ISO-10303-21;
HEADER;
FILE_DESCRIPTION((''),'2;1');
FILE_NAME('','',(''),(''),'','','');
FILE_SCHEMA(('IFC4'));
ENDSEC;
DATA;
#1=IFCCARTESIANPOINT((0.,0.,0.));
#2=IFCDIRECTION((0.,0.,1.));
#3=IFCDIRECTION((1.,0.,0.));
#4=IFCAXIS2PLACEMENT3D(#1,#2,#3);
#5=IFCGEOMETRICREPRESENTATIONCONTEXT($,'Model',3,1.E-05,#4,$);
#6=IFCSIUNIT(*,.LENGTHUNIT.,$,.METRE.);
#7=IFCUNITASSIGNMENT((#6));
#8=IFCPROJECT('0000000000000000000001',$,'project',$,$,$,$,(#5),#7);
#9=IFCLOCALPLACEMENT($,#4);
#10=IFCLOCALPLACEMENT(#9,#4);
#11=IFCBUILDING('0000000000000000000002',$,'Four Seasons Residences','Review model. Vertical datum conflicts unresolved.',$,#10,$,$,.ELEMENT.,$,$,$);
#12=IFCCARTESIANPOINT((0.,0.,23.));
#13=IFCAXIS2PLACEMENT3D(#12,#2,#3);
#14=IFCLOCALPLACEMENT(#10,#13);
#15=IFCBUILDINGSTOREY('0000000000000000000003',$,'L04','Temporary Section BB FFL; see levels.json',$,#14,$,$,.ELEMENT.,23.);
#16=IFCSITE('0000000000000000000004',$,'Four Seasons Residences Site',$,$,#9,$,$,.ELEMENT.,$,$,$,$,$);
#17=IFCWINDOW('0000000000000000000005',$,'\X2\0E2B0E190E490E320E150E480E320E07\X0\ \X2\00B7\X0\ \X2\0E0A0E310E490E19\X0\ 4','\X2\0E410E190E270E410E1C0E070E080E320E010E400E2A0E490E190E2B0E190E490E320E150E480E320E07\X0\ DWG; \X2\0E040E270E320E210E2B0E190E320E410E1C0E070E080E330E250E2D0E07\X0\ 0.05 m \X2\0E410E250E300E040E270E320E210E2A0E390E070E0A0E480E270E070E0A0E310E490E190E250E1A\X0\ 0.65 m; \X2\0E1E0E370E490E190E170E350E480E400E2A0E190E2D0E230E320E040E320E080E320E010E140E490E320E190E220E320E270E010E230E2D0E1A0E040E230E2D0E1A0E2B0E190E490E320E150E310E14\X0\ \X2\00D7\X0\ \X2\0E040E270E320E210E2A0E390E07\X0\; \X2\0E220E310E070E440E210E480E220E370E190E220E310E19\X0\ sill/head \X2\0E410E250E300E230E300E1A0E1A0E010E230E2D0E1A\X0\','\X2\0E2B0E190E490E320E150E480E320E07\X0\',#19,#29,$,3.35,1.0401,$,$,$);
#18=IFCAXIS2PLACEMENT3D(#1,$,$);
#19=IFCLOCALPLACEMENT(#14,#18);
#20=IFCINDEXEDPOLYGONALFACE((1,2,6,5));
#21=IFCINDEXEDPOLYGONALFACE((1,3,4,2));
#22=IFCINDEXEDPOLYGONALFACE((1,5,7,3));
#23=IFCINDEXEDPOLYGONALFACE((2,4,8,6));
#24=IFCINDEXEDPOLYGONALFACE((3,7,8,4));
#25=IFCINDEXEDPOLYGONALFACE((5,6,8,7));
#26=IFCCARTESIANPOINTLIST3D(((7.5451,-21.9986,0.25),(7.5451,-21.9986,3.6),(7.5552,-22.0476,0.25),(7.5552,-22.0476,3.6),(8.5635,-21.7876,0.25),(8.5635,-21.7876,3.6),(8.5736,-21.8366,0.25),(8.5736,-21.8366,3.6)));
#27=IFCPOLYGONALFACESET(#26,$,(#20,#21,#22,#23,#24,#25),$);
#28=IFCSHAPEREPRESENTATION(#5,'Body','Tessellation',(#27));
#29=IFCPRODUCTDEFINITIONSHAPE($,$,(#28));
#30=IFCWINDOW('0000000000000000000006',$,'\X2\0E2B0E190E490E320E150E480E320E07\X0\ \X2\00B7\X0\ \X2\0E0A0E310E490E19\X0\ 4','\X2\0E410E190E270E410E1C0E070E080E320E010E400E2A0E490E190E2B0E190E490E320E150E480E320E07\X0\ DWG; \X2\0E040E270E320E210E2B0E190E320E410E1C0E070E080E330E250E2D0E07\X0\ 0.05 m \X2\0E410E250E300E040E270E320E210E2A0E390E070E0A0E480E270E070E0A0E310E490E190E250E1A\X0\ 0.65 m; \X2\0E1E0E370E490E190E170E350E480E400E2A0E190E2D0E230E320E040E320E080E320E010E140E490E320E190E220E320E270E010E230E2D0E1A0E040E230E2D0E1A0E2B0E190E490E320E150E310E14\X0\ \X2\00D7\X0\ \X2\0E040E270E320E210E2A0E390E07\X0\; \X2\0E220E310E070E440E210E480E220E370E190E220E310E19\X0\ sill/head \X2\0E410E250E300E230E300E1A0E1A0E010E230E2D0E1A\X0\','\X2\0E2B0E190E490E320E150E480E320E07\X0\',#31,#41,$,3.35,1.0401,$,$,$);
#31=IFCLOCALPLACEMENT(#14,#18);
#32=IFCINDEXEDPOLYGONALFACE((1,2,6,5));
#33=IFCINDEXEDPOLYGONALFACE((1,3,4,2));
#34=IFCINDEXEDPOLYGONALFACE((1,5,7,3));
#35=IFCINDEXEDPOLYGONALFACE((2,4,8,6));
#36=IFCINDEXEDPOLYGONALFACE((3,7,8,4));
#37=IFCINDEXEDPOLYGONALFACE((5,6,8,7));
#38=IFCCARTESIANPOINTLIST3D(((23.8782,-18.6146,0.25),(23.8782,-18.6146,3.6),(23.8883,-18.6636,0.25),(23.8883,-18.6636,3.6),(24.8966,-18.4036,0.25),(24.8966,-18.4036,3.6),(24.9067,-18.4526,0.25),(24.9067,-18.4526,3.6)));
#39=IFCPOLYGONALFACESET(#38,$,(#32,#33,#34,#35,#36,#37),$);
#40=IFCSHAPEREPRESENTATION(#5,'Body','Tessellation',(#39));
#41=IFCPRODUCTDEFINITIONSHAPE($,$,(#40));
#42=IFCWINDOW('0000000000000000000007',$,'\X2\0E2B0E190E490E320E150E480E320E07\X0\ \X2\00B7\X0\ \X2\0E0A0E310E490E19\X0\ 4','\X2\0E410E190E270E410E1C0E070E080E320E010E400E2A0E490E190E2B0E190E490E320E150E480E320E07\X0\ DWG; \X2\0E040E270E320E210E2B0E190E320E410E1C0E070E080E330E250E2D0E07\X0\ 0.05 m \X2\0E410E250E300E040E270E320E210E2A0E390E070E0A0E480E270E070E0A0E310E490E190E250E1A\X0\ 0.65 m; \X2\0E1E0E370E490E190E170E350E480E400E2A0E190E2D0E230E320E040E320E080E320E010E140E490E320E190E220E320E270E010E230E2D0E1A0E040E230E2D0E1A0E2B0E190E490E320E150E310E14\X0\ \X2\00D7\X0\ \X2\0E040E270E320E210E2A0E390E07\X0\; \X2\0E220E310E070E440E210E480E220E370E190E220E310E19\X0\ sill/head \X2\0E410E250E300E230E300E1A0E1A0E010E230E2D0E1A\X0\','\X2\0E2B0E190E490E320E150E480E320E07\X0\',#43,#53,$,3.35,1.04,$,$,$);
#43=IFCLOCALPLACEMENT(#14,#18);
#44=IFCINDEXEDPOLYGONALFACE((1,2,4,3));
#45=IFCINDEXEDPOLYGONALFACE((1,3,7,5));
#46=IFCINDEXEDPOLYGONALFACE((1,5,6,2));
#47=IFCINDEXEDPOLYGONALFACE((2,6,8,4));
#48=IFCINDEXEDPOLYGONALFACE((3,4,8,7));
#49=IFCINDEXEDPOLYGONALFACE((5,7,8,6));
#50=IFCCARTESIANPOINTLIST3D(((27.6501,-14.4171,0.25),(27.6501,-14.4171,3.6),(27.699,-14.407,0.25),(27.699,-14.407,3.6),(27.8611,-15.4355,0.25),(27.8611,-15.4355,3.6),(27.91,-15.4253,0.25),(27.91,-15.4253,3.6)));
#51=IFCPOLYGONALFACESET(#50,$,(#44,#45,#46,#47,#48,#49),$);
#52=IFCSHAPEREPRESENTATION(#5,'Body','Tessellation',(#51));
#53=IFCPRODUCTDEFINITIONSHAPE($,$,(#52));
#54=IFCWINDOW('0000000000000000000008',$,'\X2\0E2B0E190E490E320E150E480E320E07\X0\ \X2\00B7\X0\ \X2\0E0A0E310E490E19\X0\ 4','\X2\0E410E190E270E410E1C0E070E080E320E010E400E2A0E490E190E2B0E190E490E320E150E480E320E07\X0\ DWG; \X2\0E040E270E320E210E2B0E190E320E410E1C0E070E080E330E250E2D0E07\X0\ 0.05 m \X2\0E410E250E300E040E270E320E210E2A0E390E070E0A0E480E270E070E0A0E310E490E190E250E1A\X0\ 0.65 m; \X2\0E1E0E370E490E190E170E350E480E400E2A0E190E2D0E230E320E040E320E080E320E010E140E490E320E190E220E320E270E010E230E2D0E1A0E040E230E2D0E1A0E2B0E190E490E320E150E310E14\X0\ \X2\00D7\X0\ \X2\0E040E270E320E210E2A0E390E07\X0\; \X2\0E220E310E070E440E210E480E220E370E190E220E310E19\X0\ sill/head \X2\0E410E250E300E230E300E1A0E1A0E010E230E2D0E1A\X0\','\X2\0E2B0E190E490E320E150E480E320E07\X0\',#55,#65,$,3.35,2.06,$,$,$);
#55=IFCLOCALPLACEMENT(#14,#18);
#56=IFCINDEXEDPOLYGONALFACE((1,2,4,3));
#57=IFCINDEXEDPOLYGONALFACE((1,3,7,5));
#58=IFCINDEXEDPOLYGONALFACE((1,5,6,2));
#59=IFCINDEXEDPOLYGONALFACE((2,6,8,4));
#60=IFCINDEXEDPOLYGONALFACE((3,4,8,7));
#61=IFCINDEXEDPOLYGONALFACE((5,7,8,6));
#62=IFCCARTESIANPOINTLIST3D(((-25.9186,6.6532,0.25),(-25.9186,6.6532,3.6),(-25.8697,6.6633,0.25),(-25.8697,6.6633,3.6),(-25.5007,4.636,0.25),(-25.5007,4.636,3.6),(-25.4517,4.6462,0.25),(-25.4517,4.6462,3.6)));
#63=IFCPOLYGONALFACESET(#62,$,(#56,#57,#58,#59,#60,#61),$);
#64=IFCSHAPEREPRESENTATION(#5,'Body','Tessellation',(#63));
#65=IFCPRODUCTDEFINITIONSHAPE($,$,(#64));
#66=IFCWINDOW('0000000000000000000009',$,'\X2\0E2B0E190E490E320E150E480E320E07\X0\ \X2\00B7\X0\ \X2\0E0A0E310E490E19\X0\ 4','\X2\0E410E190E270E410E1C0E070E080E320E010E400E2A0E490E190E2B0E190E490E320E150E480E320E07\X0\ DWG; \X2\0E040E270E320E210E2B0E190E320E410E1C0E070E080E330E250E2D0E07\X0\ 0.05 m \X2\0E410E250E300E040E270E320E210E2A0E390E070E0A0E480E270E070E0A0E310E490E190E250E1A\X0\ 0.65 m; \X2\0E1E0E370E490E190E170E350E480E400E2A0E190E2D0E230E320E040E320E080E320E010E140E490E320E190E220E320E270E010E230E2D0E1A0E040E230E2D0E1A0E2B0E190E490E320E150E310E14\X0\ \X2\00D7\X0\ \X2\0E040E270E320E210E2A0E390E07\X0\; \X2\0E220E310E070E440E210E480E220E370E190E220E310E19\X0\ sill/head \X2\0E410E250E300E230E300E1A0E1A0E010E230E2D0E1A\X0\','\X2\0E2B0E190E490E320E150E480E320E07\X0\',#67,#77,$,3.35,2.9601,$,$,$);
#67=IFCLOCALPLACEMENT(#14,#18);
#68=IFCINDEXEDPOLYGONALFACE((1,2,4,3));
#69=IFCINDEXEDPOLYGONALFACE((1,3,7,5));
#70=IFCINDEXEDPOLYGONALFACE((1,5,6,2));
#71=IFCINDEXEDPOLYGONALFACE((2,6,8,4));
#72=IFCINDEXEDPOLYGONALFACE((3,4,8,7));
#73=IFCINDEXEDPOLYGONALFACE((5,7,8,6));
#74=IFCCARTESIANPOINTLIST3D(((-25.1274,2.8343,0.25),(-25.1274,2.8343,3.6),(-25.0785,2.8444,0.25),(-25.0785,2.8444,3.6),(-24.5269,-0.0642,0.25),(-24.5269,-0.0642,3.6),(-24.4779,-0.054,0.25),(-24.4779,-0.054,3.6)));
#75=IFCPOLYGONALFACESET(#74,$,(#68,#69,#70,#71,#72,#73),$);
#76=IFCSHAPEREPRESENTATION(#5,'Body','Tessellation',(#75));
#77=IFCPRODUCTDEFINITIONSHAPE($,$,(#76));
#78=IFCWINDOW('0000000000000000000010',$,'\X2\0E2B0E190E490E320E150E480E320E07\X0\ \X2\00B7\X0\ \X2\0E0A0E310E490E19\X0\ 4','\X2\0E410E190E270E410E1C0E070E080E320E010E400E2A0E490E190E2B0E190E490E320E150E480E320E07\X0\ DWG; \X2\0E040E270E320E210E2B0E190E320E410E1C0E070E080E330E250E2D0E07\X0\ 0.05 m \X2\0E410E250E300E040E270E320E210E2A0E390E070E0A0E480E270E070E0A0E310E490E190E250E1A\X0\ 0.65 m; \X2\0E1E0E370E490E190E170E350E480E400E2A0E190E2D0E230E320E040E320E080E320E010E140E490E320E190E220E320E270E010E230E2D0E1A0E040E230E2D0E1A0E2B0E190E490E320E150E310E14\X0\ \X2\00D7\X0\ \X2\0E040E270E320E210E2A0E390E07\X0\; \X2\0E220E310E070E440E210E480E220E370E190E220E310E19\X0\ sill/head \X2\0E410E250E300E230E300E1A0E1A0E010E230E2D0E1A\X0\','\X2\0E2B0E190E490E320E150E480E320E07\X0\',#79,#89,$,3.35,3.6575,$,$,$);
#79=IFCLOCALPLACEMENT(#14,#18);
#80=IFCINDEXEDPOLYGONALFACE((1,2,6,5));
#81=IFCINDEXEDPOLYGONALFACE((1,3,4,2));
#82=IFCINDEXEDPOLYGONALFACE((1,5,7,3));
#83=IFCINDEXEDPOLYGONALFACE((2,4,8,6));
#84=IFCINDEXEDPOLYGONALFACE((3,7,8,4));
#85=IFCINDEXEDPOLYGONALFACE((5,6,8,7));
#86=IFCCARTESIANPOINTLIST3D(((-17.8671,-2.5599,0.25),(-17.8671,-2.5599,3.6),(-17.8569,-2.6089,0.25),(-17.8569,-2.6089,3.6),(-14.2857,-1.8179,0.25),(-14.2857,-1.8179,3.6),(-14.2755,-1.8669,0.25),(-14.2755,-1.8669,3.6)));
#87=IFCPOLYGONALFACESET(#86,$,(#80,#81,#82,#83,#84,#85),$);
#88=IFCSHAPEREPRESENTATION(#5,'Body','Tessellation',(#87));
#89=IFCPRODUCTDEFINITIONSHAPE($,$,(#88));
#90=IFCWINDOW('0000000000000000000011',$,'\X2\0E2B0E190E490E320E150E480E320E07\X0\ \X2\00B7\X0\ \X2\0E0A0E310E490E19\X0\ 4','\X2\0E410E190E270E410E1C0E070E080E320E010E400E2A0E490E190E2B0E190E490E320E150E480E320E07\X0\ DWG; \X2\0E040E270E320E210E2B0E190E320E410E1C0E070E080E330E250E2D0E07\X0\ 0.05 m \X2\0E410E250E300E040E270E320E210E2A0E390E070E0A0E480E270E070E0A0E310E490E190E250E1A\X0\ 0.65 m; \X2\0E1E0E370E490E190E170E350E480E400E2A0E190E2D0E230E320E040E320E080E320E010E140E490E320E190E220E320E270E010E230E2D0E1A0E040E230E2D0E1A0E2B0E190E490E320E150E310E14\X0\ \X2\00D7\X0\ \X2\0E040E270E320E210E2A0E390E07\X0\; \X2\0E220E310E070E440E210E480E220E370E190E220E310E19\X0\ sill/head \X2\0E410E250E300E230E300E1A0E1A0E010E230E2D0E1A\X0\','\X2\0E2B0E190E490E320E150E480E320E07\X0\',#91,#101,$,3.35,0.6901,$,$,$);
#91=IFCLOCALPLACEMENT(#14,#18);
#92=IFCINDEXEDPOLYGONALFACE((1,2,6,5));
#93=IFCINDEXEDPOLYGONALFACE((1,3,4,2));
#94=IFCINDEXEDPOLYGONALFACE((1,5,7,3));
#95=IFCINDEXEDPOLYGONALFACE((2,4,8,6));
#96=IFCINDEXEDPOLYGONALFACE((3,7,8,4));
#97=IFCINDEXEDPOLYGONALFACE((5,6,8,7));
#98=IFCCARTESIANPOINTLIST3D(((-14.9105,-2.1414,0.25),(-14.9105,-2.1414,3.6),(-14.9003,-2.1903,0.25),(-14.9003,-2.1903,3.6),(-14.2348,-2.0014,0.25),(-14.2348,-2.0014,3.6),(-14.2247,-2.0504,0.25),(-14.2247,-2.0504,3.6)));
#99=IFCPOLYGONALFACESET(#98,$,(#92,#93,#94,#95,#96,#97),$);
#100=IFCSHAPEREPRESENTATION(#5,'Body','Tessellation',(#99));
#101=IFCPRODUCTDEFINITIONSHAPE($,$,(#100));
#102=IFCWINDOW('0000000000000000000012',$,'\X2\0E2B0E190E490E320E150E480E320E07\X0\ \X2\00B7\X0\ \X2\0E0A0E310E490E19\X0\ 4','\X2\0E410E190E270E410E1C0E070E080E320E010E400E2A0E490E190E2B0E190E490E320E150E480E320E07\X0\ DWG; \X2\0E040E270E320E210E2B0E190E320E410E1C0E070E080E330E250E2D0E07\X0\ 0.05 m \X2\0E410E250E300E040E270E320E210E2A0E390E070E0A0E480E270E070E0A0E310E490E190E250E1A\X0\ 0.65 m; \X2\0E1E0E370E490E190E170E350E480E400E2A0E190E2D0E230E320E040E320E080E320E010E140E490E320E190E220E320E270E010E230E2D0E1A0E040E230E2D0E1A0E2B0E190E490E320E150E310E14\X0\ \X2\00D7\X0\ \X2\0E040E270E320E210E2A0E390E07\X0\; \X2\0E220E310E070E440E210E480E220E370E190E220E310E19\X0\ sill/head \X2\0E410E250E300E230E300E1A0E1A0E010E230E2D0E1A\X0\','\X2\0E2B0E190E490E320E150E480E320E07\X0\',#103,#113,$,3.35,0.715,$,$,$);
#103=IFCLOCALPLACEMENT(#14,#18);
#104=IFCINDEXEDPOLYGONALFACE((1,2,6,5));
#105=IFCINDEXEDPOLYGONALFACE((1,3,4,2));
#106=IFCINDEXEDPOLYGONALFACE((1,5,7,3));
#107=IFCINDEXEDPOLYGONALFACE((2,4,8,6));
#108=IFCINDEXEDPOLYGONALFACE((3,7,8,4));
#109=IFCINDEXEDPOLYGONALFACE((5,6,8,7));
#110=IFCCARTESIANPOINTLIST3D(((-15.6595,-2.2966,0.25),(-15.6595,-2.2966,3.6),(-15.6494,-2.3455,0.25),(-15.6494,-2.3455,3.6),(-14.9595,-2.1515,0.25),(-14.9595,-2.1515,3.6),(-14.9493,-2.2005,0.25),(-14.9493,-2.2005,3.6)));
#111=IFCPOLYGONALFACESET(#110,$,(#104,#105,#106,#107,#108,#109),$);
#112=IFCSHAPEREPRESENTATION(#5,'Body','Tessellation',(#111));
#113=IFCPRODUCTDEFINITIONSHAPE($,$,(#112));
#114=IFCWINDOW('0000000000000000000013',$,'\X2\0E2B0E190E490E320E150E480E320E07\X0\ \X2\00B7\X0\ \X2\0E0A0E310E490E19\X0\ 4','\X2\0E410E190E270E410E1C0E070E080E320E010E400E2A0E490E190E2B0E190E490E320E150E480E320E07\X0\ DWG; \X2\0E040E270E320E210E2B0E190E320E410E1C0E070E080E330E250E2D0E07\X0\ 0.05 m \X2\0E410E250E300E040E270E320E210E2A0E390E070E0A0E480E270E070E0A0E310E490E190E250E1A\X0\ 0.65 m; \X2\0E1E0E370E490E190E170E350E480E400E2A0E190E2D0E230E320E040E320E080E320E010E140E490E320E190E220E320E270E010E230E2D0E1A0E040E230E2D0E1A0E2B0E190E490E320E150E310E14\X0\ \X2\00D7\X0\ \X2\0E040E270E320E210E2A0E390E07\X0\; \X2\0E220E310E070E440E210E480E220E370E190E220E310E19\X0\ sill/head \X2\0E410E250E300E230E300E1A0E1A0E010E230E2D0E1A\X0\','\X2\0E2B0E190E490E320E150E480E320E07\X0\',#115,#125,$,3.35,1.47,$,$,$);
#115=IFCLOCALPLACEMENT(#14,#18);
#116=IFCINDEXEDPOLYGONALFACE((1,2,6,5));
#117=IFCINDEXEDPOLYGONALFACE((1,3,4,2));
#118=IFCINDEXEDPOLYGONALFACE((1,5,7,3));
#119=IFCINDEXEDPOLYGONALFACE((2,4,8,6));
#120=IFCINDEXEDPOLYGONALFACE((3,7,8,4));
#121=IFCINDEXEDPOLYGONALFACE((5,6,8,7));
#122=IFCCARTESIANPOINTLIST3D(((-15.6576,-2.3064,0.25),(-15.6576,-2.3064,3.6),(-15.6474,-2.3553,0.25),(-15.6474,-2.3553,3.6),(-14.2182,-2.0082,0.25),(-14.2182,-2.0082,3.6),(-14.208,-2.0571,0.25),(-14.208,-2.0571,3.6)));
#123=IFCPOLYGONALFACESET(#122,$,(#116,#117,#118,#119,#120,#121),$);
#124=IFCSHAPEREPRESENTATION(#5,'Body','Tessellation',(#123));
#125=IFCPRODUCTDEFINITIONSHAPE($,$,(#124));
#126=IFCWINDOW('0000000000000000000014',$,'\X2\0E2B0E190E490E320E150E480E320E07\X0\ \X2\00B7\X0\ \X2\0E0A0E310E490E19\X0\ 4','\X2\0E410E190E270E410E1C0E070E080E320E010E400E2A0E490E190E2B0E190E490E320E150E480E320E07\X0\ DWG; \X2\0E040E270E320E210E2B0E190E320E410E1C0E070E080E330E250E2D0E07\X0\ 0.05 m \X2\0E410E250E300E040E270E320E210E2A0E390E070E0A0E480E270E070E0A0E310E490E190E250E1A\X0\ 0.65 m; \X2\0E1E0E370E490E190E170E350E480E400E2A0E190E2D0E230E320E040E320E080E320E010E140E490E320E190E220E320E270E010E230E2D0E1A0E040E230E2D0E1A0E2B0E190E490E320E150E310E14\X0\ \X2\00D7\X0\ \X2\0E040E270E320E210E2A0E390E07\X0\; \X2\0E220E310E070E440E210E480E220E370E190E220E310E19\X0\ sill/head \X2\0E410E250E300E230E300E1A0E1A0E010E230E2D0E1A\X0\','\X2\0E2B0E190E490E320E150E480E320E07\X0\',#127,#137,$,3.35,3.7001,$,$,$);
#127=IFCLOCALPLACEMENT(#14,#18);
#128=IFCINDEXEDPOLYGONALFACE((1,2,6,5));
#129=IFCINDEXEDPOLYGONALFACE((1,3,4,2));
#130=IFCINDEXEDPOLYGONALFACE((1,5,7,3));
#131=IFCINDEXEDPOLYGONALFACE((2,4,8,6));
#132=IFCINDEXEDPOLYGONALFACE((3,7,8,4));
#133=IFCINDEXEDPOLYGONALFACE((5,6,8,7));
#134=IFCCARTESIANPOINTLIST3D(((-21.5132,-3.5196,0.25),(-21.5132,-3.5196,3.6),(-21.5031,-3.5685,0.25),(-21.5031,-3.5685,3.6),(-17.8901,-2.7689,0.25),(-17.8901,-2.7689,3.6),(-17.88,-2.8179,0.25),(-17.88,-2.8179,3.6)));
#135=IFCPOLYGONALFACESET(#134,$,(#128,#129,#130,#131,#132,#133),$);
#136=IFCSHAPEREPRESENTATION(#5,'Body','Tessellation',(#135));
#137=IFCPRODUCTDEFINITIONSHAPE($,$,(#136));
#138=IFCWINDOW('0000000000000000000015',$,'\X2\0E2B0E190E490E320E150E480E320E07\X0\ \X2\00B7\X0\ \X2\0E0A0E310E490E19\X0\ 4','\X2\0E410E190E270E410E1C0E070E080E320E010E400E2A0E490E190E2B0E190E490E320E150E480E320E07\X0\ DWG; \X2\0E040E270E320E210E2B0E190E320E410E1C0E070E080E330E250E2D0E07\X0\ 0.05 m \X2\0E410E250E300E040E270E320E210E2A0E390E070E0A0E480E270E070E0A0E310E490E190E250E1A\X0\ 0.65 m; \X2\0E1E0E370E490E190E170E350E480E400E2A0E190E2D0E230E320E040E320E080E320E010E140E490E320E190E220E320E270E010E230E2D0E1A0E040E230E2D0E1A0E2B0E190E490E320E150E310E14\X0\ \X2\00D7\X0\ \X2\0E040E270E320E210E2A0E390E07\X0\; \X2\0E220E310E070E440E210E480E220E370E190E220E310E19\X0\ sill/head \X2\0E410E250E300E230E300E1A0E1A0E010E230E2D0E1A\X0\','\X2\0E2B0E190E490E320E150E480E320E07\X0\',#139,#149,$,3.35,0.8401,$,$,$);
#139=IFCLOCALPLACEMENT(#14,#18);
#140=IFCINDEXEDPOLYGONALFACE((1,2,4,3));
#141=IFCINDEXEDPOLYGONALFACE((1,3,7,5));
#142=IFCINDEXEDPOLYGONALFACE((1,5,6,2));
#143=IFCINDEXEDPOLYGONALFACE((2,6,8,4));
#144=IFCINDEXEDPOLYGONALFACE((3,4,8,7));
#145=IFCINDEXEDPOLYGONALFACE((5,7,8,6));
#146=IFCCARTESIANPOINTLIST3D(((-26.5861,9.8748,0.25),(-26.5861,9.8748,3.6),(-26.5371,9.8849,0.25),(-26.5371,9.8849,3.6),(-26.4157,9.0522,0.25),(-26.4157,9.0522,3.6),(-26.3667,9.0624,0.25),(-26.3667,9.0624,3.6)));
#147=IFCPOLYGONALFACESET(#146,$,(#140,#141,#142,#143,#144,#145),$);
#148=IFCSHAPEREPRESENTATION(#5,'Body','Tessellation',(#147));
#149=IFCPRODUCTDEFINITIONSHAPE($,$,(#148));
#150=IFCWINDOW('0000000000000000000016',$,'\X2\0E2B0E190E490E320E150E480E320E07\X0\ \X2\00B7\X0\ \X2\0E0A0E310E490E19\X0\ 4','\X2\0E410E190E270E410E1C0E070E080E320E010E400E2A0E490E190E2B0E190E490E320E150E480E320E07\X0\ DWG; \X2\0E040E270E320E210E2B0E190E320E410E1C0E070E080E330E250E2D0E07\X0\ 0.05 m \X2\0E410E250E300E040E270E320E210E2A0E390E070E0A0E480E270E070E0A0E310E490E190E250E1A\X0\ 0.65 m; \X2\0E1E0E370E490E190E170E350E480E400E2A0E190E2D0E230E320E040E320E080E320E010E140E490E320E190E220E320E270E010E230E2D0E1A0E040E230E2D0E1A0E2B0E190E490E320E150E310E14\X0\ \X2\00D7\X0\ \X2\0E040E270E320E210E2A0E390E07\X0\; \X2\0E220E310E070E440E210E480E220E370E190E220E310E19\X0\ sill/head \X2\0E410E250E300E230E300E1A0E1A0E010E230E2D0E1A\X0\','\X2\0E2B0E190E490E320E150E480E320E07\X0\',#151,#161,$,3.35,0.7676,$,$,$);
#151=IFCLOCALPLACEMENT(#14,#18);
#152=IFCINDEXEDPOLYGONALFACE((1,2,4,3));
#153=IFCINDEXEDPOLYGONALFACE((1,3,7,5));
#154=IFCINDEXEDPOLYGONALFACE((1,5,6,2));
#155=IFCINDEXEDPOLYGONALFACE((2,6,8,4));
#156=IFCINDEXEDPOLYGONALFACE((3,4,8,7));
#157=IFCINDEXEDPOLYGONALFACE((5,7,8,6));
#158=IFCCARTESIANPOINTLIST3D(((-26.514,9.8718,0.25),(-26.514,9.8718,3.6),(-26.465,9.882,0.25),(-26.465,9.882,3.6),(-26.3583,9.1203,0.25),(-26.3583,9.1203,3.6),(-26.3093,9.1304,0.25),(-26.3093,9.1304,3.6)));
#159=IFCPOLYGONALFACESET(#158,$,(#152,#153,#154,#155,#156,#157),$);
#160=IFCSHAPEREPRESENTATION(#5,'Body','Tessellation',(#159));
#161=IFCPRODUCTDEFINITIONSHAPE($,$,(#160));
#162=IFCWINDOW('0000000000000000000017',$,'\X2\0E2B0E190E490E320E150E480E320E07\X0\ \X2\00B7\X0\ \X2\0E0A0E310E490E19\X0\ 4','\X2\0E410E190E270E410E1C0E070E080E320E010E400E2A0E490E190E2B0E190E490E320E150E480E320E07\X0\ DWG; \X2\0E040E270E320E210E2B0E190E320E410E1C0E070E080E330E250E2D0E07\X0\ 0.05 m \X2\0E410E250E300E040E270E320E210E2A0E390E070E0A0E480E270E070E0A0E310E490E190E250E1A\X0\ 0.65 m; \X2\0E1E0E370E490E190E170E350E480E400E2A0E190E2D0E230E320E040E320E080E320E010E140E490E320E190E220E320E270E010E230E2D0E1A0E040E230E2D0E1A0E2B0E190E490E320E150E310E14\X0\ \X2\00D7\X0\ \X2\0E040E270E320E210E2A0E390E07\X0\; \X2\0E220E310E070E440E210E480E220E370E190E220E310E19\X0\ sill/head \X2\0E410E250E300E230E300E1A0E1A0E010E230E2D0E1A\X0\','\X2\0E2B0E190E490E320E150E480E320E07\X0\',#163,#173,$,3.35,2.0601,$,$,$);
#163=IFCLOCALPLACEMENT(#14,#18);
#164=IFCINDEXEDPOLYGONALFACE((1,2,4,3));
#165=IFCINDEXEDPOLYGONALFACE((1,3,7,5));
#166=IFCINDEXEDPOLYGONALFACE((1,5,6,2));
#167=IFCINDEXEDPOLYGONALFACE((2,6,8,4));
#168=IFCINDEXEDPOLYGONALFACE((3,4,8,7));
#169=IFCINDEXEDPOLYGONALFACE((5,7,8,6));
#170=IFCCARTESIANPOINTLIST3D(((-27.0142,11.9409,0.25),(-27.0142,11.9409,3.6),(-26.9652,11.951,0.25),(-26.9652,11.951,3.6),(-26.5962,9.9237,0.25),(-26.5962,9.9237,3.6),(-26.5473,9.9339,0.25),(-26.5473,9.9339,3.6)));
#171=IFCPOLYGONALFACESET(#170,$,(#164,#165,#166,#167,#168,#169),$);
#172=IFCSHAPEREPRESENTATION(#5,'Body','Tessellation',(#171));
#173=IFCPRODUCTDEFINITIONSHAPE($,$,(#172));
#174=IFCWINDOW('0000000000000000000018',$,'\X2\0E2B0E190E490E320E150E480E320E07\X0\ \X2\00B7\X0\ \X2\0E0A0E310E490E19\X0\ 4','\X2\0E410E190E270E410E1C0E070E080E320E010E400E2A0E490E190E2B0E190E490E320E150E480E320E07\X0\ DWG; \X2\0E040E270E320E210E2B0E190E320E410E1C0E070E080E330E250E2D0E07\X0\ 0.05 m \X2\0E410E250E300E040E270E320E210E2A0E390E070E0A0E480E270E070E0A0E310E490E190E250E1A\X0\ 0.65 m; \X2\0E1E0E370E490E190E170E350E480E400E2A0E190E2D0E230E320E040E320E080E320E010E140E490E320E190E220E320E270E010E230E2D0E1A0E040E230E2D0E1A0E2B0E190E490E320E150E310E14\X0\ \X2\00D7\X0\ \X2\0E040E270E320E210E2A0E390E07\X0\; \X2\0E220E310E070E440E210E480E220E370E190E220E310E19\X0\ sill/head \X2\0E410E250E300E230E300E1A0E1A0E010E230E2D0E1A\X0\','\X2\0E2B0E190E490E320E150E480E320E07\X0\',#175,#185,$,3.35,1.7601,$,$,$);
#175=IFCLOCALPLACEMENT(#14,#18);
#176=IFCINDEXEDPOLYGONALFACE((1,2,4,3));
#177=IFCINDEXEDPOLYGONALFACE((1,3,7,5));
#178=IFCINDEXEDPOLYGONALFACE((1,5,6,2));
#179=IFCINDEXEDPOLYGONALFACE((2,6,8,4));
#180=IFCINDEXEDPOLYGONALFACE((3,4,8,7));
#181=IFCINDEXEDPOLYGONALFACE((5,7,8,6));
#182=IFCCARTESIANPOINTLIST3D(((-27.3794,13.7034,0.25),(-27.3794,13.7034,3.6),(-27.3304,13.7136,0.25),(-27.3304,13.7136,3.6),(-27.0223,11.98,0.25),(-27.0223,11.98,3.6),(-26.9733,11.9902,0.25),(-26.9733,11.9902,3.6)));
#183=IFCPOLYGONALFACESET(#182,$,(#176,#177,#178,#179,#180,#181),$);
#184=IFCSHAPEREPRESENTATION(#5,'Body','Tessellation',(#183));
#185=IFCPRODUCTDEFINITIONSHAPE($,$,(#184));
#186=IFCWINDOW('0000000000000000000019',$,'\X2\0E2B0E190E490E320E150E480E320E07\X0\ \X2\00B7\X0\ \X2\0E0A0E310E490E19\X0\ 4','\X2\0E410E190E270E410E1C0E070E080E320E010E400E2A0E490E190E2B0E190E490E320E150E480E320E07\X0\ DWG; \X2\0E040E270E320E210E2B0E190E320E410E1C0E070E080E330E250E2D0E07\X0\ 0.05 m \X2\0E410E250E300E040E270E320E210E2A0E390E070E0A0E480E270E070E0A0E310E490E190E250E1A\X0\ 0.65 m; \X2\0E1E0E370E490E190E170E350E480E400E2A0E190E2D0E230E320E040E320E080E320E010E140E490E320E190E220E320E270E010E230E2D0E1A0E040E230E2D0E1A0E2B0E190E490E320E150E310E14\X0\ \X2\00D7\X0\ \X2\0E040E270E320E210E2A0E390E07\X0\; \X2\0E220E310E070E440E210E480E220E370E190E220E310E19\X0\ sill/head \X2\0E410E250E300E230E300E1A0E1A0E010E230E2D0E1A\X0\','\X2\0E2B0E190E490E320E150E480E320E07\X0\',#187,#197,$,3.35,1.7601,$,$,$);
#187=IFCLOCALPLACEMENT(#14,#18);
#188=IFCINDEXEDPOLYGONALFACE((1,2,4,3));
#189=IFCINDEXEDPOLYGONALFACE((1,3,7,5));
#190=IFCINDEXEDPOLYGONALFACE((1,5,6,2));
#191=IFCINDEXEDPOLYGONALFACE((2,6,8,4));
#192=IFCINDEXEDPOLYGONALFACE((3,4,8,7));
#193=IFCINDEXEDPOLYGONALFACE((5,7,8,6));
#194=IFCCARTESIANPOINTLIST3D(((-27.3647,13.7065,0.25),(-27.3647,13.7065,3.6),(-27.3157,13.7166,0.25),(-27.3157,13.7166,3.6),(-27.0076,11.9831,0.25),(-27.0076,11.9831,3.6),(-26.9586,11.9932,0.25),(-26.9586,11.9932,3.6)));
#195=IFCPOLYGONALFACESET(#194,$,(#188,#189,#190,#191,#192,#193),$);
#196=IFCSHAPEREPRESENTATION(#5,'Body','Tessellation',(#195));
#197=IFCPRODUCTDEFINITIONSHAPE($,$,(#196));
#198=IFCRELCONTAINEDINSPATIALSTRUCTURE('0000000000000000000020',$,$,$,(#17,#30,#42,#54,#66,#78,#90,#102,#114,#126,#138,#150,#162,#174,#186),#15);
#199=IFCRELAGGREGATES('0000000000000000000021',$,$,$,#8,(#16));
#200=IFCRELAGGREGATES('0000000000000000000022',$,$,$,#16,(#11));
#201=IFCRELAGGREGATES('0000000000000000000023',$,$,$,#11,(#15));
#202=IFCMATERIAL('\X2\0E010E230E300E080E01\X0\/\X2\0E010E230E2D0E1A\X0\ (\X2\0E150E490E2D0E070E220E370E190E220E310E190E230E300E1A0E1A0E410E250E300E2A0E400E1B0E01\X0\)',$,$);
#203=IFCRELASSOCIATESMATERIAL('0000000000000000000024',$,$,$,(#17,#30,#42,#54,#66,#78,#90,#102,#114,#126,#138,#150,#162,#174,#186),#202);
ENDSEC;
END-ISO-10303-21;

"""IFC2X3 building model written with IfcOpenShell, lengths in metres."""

from ifc_helpers import new_model, si_unit, frame, origin_with_axes, place, context, project, spatial, polyline, outline, extrude, material, element, save


model = new_model("IFC2X3")

# Units and contexts
model_context = context("Model", 3, precision=1e-05, world=origin_with_axes())
ifc_project = project(units=[si_unit("LENGTHUNIT", "METRE")], contexts=[model_context])

# Site, building, storey
site_placement = place(None, origin_with_axes())
site = spatial("IfcSite", under=ifc_project, at=site_placement, Name="Four Seasons Residences Site", CompositionType="ELEMENT")
building_placement = place(site_placement, origin_with_axes())
building = spatial("IfcBuilding", under=site, at=building_placement, Name="Four Seasons Residences", Description="Review model. Vertical datum conflicts unresolved.", CompositionType="ELEMENT")
storey_placement = place(building_placement, frame((0.0, 0.0, 23.0), z_axis=(0.0, 0.0, 1.0), x_axis=(1.0, 0.0, 0.0)))
storey = spatial("IfcBuildingStorey", under=building, at=storey_placement, Name="L04", Description="Temporary Section BB FFL; see levels.json", CompositionType="ELEMENT", Elevation=23.0)

# Windows
ifc_material = material(Name="กระจก/กรอบ (ต้องยืนยันระบบและสเปก)")
window_1_placement = place(storey_placement, origin_with_axes())
element("IfcWindow", 1, at=window_1_placement, inside=storey, material=ifc_material, Name="หน้าต่าง · ชั้น 4", Description="แนวแผงจากเส้นหน้าต่าง DWG; ความหนาแผงจำลอง 0.05 m และความสูงช่วงชั้นลบ 0.65 m; พื้นที่เสนอราคาจากด้านยาวกรอบครอบหน้าตัด × ความสูง; ยังไม่ยืนยัน sill/head และระบบกรอบ", ObjectType="หน้าต่าง", OverallHeight=3.35, OverallWidth=1.0401, context=model_context, shape_type="SweptSolid", body=[
    extrude(outline(polyline([(7.5552, -22.0476), (7.5451, -21.9986), (8.5635, -21.7876), (8.5736, -21.8366), (7.5552, -22.0476)])), frame((0.0, 0.0, 0.25), z_axis=(0.0, 0.0, 1.0), x_axis=(1.0, 0.0, 0.0)), (0.0, 0.0, 1.0), 3.35),
])
window_2_placement = place(storey_placement, origin_with_axes())
element("IfcWindow", 2, at=window_2_placement, inside=storey, material=ifc_material, Name="หน้าต่าง · ชั้น 4", Description="แนวแผงจากเส้นหน้าต่าง DWG; ความหนาแผงจำลอง 0.05 m และความสูงช่วงชั้นลบ 0.65 m; พื้นที่เสนอราคาจากด้านยาวกรอบครอบหน้าตัด × ความสูง; ยังไม่ยืนยัน sill/head และระบบกรอบ", ObjectType="หน้าต่าง", OverallHeight=3.35, OverallWidth=1.0401, context=model_context, shape_type="SweptSolid", body=[
    extrude(outline(polyline([(24.8966, -18.4036), (24.9067, -18.4526), (23.8883, -18.6636), (23.8782, -18.6146), (24.8966, -18.4036)])), frame((0.0, 0.0, 0.25), z_axis=(0.0, 0.0, 1.0), x_axis=(1.0, 0.0, 0.0)), (0.0, 0.0, 1.0), 3.35),
])
window_3_placement = place(storey_placement, origin_with_axes())
element("IfcWindow", 3, at=window_3_placement, inside=storey, material=ifc_material, Name="หน้าต่าง · ชั้น 4", Description="แนวแผงจากเส้นหน้าต่าง DWG; ความหนาแผงจำลอง 0.05 m และความสูงช่วงชั้นลบ 0.65 m; พื้นที่เสนอราคาจากด้านยาวกรอบครอบหน้าตัด × ความสูง; ยังไม่ยืนยัน sill/head และระบบกรอบ", ObjectType="หน้าต่าง", OverallHeight=3.35, OverallWidth=1.04, context=model_context, shape_type="SweptSolid", body=[
    extrude(outline(polyline([(27.91, -15.4253), (27.8611, -15.4355), (27.6501, -14.4171), (27.699, -14.407), (27.91, -15.4253)])), frame((0.0, 0.0, 0.25), z_axis=(0.0, 0.0, 1.0), x_axis=(1.0, 0.0, 0.0)), (0.0, 0.0, 1.0), 3.35),
])
window_4_placement = place(storey_placement, origin_with_axes())
element("IfcWindow", 4, at=window_4_placement, inside=storey, material=ifc_material, Name="หน้าต่าง · ชั้น 4", Description="แนวแผงจากเส้นหน้าต่าง DWG; ความหนาแผงจำลอง 0.05 m และความสูงช่วงชั้นลบ 0.65 m; พื้นที่เสนอราคาจากด้านยาวกรอบครอบหน้าตัด × ความสูง; ยังไม่ยืนยัน sill/head และระบบกรอบ", ObjectType="หน้าต่าง", OverallHeight=3.35, OverallWidth=2.06, context=model_context, shape_type="SweptSolid", body=[
    extrude(outline(polyline([(-25.4517, 4.6462), (-25.5007, 4.636), (-25.9186, 6.6532), (-25.8697, 6.6633), (-25.4517, 4.6462)])), frame((0.0, 0.0, 0.25), z_axis=(0.0, 0.0, 1.0), x_axis=(1.0, 0.0, 0.0)), (0.0, 0.0, 1.0), 3.35),
])
window_5_placement = place(storey_placement, origin_with_axes())
element("IfcWindow", 5, at=window_5_placement, inside=storey, material=ifc_material, Name="หน้าต่าง · ชั้น 4", Description="แนวแผงจากเส้นหน้าต่าง DWG; ความหนาแผงจำลอง 0.05 m และความสูงช่วงชั้นลบ 0.65 m; พื้นที่เสนอราคาจากด้านยาวกรอบครอบหน้าตัด × ความสูง; ยังไม่ยืนยัน sill/head และระบบกรอบ", ObjectType="หน้าต่าง", OverallHeight=3.35, OverallWidth=2.9601, context=model_context, shape_type="SweptSolid", body=[
    extrude(outline(polyline([(-24.4779, -0.054), (-24.5269, -0.0642), (-25.1274, 2.8343), (-25.0785, 2.8444), (-24.4779, -0.054)])), frame((0.0, 0.0, 0.25), z_axis=(0.0, 0.0, 1.0), x_axis=(1.0, 0.0, 0.0)), (0.0, 0.0, 1.0), 3.35),
])
window_6_placement = place(storey_placement, origin_with_axes())
element("IfcWindow", 6, at=window_6_placement, inside=storey, material=ifc_material, Name="หน้าต่าง · ชั้น 4", Description="แนวแผงจากเส้นหน้าต่าง DWG; ความหนาแผงจำลอง 0.05 m และความสูงช่วงชั้นลบ 0.65 m; พื้นที่เสนอราคาจากด้านยาวกรอบครอบหน้าตัด × ความสูง; ยังไม่ยืนยัน sill/head และระบบกรอบ", ObjectType="หน้าต่าง", OverallHeight=3.35, OverallWidth=3.6575, context=model_context, shape_type="SweptSolid", body=[
    extrude(outline(polyline([(-14.2857, -1.8179), (-14.2755, -1.8669), (-17.8569, -2.6089), (-17.8671, -2.5599), (-14.2857, -1.8179)])), frame((0.0, 0.0, 0.25), z_axis=(0.0, 0.0, 1.0), x_axis=(1.0, 0.0, 0.0)), (0.0, 0.0, 1.0), 3.35),
])
window_7_placement = place(storey_placement, origin_with_axes())
element("IfcWindow", 7, at=window_7_placement, inside=storey, material=ifc_material, Name="หน้าต่าง · ชั้น 4", Description="แนวแผงจากเส้นหน้าต่าง DWG; ความหนาแผงจำลอง 0.05 m และความสูงช่วงชั้นลบ 0.65 m; พื้นที่เสนอราคาจากด้านยาวกรอบครอบหน้าตัด × ความสูง; ยังไม่ยืนยัน sill/head และระบบกรอบ", ObjectType="หน้าต่าง", OverallHeight=3.35, OverallWidth=0.6901, context=model_context, shape_type="SweptSolid", body=[
    extrude(outline(polyline([(-14.9003, -2.1903), (-14.9105, -2.1414), (-14.2348, -2.0014), (-14.2247, -2.0504), (-14.9003, -2.1903)])), frame((0.0, 0.0, 0.25), z_axis=(0.0, 0.0, 1.0), x_axis=(1.0, 0.0, 0.0)), (0.0, 0.0, 1.0), 3.35),
])
window_8_placement = place(storey_placement, origin_with_axes())
element("IfcWindow", 8, at=window_8_placement, inside=storey, material=ifc_material, Name="หน้าต่าง · ชั้น 4", Description="แนวแผงจากเส้นหน้าต่าง DWG; ความหนาแผงจำลอง 0.05 m และความสูงช่วงชั้นลบ 0.65 m; พื้นที่เสนอราคาจากด้านยาวกรอบครอบหน้าตัด × ความสูง; ยังไม่ยืนยัน sill/head และระบบกรอบ", ObjectType="หน้าต่าง", OverallHeight=3.35, OverallWidth=0.715, context=model_context, shape_type="SweptSolid", body=[
    extrude(outline(polyline([(-15.6494, -2.3455), (-15.6595, -2.2966), (-14.9595, -2.1515), (-14.9493, -2.2005), (-15.6494, -2.3455)])), frame((0.0, 0.0, 0.25), z_axis=(0.0, 0.0, 1.0), x_axis=(1.0, 0.0, 0.0)), (0.0, 0.0, 1.0), 3.35),
])
window_9_placement = place(storey_placement, origin_with_axes())
element("IfcWindow", 9, at=window_9_placement, inside=storey, material=ifc_material, Name="หน้าต่าง · ชั้น 4", Description="แนวแผงจากเส้นหน้าต่าง DWG; ความหนาแผงจำลอง 0.05 m และความสูงช่วงชั้นลบ 0.65 m; พื้นที่เสนอราคาจากด้านยาวกรอบครอบหน้าตัด × ความสูง; ยังไม่ยืนยัน sill/head และระบบกรอบ", ObjectType="หน้าต่าง", OverallHeight=3.35, OverallWidth=1.47, context=model_context, shape_type="SweptSolid", body=[
    extrude(outline(polyline([(-14.2182, -2.0082), (-14.208, -2.0571), (-15.6474, -2.3553), (-15.6576, -2.3064), (-14.2182, -2.0082)])), frame((0.0, 0.0, 0.25), z_axis=(0.0, 0.0, 1.0), x_axis=(1.0, 0.0, 0.0)), (0.0, 0.0, 1.0), 3.35),
])
window_10_placement = place(storey_placement, origin_with_axes())
element("IfcWindow", 10, at=window_10_placement, inside=storey, material=ifc_material, Name="หน้าต่าง · ชั้น 4", Description="แนวแผงจากเส้นหน้าต่าง DWG; ความหนาแผงจำลอง 0.05 m และความสูงช่วงชั้นลบ 0.65 m; พื้นที่เสนอราคาจากด้านยาวกรอบครอบหน้าตัด × ความสูง; ยังไม่ยืนยัน sill/head และระบบกรอบ", ObjectType="หน้าต่าง", OverallHeight=3.35, OverallWidth=3.7001, context=model_context, shape_type="SweptSolid", body=[
    extrude(outline(polyline([(-17.8901, -2.7689), (-17.88, -2.8179), (-21.5031, -3.5685), (-21.5132, -3.5196), (-17.8901, -2.7689)])), frame((0.0, 0.0, 0.25), z_axis=(0.0, 0.0, 1.0), x_axis=(1.0, 0.0, 0.0)), (0.0, 0.0, 1.0), 3.35),
])
window_11_placement = place(storey_placement, origin_with_axes())
element("IfcWindow", 11, at=window_11_placement, inside=storey, material=ifc_material, Name="หน้าต่าง · ชั้น 4", Description="แนวแผงจากเส้นหน้าต่าง DWG; ความหนาแผงจำลอง 0.05 m และความสูงช่วงชั้นลบ 0.65 m; พื้นที่เสนอราคาจากด้านยาวกรอบครอบหน้าตัด × ความสูง; ยังไม่ยืนยัน sill/head และระบบกรอบ", ObjectType="หน้าต่าง", OverallHeight=3.35, OverallWidth=0.8401, context=model_context, shape_type="SweptSolid", body=[
    extrude(outline(polyline([(-26.3667, 9.0624), (-26.4157, 9.0522), (-26.5861, 9.8748), (-26.5371, 9.8849), (-26.3667, 9.0624)])), frame((0.0, 0.0, 0.25), z_axis=(0.0, 0.0, 1.0), x_axis=(1.0, 0.0, 0.0)), (0.0, 0.0, 1.0), 3.35),
])
window_12_placement = place(storey_placement, origin_with_axes())
element("IfcWindow", 12, at=window_12_placement, inside=storey, material=ifc_material, Name="หน้าต่าง · ชั้น 4", Description="แนวแผงจากเส้นหน้าต่าง DWG; ความหนาแผงจำลอง 0.05 m และความสูงช่วงชั้นลบ 0.65 m; พื้นที่เสนอราคาจากด้านยาวกรอบครอบหน้าตัด × ความสูง; ยังไม่ยืนยัน sill/head และระบบกรอบ", ObjectType="หน้าต่าง", OverallHeight=3.35, OverallWidth=0.7676, context=model_context, shape_type="SweptSolid", body=[
    extrude(outline(polyline([(-26.3093, 9.1304), (-26.3583, 9.1203), (-26.514, 9.8718), (-26.465, 9.882), (-26.3093, 9.1304)])), frame((0.0, 0.0, 0.25), z_axis=(0.0, 0.0, 1.0), x_axis=(1.0, 0.0, 0.0)), (0.0, 0.0, 1.0), 3.35),
])
window_13_placement = place(storey_placement, origin_with_axes())
element("IfcWindow", 13, at=window_13_placement, inside=storey, material=ifc_material, Name="หน้าต่าง · ชั้น 4", Description="แนวแผงจากเส้นหน้าต่าง DWG; ความหนาแผงจำลอง 0.05 m และความสูงช่วงชั้นลบ 0.65 m; พื้นที่เสนอราคาจากด้านยาวกรอบครอบหน้าตัด × ความสูง; ยังไม่ยืนยัน sill/head และระบบกรอบ", ObjectType="หน้าต่าง", OverallHeight=3.35, OverallWidth=2.0601, context=model_context, shape_type="SweptSolid", body=[
    extrude(outline(polyline([(-26.5473, 9.9339), (-26.5962, 9.9237), (-27.0142, 11.9409), (-26.9652, 11.951), (-26.5473, 9.9339)])), frame((0.0, 0.0, 0.25), z_axis=(0.0, 0.0, 1.0), x_axis=(1.0, 0.0, 0.0)), (0.0, 0.0, 1.0), 3.35),
])
window_14_placement = place(storey_placement, origin_with_axes())
element("IfcWindow", 14, at=window_14_placement, inside=storey, material=ifc_material, Name="หน้าต่าง · ชั้น 4", Description="แนวแผงจากเส้นหน้าต่าง DWG; ความหนาแผงจำลอง 0.05 m และความสูงช่วงชั้นลบ 0.65 m; พื้นที่เสนอราคาจากด้านยาวกรอบครอบหน้าตัด × ความสูง; ยังไม่ยืนยัน sill/head และระบบกรอบ", ObjectType="หน้าต่าง", OverallHeight=3.35, OverallWidth=1.7601, context=model_context, shape_type="SweptSolid", body=[
    extrude(outline(polyline([(-26.9733, 11.9902), (-27.0223, 11.98), (-27.3794, 13.7034), (-27.3304, 13.7136), (-26.9733, 11.9902)])), frame((0.0, 0.0, 0.25), z_axis=(0.0, 0.0, 1.0), x_axis=(1.0, 0.0, 0.0)), (0.0, 0.0, 1.0), 3.35),
])
window_15_placement = place(storey_placement, origin_with_axes())
element("IfcWindow", 15, at=window_15_placement, inside=storey, material=ifc_material, Name="หน้าต่าง · ชั้น 4", Description="แนวแผงจากเส้นหน้าต่าง DWG; ความหนาแผงจำลอง 0.05 m และความสูงช่วงชั้นลบ 0.65 m; พื้นที่เสนอราคาจากด้านยาวกรอบครอบหน้าตัด × ความสูง; ยังไม่ยืนยัน sill/head และระบบกรอบ", ObjectType="หน้าต่าง", OverallHeight=3.35, OverallWidth=1.7601, context=model_context, shape_type="SweptSolid", body=[
    extrude(outline(polyline([(-26.9586, 11.9932), (-27.0076, 11.9831), (-27.3647, 13.7065), (-27.3157, 13.7166), (-26.9586, 11.9932)])), frame((0.0, 0.0, 0.25), z_axis=(0.0, 0.0, 1.0), x_axis=(1.0, 0.0, 0.0)), (0.0, 0.0, 1.0), 3.35),
])

save(model, "model.ifc")
